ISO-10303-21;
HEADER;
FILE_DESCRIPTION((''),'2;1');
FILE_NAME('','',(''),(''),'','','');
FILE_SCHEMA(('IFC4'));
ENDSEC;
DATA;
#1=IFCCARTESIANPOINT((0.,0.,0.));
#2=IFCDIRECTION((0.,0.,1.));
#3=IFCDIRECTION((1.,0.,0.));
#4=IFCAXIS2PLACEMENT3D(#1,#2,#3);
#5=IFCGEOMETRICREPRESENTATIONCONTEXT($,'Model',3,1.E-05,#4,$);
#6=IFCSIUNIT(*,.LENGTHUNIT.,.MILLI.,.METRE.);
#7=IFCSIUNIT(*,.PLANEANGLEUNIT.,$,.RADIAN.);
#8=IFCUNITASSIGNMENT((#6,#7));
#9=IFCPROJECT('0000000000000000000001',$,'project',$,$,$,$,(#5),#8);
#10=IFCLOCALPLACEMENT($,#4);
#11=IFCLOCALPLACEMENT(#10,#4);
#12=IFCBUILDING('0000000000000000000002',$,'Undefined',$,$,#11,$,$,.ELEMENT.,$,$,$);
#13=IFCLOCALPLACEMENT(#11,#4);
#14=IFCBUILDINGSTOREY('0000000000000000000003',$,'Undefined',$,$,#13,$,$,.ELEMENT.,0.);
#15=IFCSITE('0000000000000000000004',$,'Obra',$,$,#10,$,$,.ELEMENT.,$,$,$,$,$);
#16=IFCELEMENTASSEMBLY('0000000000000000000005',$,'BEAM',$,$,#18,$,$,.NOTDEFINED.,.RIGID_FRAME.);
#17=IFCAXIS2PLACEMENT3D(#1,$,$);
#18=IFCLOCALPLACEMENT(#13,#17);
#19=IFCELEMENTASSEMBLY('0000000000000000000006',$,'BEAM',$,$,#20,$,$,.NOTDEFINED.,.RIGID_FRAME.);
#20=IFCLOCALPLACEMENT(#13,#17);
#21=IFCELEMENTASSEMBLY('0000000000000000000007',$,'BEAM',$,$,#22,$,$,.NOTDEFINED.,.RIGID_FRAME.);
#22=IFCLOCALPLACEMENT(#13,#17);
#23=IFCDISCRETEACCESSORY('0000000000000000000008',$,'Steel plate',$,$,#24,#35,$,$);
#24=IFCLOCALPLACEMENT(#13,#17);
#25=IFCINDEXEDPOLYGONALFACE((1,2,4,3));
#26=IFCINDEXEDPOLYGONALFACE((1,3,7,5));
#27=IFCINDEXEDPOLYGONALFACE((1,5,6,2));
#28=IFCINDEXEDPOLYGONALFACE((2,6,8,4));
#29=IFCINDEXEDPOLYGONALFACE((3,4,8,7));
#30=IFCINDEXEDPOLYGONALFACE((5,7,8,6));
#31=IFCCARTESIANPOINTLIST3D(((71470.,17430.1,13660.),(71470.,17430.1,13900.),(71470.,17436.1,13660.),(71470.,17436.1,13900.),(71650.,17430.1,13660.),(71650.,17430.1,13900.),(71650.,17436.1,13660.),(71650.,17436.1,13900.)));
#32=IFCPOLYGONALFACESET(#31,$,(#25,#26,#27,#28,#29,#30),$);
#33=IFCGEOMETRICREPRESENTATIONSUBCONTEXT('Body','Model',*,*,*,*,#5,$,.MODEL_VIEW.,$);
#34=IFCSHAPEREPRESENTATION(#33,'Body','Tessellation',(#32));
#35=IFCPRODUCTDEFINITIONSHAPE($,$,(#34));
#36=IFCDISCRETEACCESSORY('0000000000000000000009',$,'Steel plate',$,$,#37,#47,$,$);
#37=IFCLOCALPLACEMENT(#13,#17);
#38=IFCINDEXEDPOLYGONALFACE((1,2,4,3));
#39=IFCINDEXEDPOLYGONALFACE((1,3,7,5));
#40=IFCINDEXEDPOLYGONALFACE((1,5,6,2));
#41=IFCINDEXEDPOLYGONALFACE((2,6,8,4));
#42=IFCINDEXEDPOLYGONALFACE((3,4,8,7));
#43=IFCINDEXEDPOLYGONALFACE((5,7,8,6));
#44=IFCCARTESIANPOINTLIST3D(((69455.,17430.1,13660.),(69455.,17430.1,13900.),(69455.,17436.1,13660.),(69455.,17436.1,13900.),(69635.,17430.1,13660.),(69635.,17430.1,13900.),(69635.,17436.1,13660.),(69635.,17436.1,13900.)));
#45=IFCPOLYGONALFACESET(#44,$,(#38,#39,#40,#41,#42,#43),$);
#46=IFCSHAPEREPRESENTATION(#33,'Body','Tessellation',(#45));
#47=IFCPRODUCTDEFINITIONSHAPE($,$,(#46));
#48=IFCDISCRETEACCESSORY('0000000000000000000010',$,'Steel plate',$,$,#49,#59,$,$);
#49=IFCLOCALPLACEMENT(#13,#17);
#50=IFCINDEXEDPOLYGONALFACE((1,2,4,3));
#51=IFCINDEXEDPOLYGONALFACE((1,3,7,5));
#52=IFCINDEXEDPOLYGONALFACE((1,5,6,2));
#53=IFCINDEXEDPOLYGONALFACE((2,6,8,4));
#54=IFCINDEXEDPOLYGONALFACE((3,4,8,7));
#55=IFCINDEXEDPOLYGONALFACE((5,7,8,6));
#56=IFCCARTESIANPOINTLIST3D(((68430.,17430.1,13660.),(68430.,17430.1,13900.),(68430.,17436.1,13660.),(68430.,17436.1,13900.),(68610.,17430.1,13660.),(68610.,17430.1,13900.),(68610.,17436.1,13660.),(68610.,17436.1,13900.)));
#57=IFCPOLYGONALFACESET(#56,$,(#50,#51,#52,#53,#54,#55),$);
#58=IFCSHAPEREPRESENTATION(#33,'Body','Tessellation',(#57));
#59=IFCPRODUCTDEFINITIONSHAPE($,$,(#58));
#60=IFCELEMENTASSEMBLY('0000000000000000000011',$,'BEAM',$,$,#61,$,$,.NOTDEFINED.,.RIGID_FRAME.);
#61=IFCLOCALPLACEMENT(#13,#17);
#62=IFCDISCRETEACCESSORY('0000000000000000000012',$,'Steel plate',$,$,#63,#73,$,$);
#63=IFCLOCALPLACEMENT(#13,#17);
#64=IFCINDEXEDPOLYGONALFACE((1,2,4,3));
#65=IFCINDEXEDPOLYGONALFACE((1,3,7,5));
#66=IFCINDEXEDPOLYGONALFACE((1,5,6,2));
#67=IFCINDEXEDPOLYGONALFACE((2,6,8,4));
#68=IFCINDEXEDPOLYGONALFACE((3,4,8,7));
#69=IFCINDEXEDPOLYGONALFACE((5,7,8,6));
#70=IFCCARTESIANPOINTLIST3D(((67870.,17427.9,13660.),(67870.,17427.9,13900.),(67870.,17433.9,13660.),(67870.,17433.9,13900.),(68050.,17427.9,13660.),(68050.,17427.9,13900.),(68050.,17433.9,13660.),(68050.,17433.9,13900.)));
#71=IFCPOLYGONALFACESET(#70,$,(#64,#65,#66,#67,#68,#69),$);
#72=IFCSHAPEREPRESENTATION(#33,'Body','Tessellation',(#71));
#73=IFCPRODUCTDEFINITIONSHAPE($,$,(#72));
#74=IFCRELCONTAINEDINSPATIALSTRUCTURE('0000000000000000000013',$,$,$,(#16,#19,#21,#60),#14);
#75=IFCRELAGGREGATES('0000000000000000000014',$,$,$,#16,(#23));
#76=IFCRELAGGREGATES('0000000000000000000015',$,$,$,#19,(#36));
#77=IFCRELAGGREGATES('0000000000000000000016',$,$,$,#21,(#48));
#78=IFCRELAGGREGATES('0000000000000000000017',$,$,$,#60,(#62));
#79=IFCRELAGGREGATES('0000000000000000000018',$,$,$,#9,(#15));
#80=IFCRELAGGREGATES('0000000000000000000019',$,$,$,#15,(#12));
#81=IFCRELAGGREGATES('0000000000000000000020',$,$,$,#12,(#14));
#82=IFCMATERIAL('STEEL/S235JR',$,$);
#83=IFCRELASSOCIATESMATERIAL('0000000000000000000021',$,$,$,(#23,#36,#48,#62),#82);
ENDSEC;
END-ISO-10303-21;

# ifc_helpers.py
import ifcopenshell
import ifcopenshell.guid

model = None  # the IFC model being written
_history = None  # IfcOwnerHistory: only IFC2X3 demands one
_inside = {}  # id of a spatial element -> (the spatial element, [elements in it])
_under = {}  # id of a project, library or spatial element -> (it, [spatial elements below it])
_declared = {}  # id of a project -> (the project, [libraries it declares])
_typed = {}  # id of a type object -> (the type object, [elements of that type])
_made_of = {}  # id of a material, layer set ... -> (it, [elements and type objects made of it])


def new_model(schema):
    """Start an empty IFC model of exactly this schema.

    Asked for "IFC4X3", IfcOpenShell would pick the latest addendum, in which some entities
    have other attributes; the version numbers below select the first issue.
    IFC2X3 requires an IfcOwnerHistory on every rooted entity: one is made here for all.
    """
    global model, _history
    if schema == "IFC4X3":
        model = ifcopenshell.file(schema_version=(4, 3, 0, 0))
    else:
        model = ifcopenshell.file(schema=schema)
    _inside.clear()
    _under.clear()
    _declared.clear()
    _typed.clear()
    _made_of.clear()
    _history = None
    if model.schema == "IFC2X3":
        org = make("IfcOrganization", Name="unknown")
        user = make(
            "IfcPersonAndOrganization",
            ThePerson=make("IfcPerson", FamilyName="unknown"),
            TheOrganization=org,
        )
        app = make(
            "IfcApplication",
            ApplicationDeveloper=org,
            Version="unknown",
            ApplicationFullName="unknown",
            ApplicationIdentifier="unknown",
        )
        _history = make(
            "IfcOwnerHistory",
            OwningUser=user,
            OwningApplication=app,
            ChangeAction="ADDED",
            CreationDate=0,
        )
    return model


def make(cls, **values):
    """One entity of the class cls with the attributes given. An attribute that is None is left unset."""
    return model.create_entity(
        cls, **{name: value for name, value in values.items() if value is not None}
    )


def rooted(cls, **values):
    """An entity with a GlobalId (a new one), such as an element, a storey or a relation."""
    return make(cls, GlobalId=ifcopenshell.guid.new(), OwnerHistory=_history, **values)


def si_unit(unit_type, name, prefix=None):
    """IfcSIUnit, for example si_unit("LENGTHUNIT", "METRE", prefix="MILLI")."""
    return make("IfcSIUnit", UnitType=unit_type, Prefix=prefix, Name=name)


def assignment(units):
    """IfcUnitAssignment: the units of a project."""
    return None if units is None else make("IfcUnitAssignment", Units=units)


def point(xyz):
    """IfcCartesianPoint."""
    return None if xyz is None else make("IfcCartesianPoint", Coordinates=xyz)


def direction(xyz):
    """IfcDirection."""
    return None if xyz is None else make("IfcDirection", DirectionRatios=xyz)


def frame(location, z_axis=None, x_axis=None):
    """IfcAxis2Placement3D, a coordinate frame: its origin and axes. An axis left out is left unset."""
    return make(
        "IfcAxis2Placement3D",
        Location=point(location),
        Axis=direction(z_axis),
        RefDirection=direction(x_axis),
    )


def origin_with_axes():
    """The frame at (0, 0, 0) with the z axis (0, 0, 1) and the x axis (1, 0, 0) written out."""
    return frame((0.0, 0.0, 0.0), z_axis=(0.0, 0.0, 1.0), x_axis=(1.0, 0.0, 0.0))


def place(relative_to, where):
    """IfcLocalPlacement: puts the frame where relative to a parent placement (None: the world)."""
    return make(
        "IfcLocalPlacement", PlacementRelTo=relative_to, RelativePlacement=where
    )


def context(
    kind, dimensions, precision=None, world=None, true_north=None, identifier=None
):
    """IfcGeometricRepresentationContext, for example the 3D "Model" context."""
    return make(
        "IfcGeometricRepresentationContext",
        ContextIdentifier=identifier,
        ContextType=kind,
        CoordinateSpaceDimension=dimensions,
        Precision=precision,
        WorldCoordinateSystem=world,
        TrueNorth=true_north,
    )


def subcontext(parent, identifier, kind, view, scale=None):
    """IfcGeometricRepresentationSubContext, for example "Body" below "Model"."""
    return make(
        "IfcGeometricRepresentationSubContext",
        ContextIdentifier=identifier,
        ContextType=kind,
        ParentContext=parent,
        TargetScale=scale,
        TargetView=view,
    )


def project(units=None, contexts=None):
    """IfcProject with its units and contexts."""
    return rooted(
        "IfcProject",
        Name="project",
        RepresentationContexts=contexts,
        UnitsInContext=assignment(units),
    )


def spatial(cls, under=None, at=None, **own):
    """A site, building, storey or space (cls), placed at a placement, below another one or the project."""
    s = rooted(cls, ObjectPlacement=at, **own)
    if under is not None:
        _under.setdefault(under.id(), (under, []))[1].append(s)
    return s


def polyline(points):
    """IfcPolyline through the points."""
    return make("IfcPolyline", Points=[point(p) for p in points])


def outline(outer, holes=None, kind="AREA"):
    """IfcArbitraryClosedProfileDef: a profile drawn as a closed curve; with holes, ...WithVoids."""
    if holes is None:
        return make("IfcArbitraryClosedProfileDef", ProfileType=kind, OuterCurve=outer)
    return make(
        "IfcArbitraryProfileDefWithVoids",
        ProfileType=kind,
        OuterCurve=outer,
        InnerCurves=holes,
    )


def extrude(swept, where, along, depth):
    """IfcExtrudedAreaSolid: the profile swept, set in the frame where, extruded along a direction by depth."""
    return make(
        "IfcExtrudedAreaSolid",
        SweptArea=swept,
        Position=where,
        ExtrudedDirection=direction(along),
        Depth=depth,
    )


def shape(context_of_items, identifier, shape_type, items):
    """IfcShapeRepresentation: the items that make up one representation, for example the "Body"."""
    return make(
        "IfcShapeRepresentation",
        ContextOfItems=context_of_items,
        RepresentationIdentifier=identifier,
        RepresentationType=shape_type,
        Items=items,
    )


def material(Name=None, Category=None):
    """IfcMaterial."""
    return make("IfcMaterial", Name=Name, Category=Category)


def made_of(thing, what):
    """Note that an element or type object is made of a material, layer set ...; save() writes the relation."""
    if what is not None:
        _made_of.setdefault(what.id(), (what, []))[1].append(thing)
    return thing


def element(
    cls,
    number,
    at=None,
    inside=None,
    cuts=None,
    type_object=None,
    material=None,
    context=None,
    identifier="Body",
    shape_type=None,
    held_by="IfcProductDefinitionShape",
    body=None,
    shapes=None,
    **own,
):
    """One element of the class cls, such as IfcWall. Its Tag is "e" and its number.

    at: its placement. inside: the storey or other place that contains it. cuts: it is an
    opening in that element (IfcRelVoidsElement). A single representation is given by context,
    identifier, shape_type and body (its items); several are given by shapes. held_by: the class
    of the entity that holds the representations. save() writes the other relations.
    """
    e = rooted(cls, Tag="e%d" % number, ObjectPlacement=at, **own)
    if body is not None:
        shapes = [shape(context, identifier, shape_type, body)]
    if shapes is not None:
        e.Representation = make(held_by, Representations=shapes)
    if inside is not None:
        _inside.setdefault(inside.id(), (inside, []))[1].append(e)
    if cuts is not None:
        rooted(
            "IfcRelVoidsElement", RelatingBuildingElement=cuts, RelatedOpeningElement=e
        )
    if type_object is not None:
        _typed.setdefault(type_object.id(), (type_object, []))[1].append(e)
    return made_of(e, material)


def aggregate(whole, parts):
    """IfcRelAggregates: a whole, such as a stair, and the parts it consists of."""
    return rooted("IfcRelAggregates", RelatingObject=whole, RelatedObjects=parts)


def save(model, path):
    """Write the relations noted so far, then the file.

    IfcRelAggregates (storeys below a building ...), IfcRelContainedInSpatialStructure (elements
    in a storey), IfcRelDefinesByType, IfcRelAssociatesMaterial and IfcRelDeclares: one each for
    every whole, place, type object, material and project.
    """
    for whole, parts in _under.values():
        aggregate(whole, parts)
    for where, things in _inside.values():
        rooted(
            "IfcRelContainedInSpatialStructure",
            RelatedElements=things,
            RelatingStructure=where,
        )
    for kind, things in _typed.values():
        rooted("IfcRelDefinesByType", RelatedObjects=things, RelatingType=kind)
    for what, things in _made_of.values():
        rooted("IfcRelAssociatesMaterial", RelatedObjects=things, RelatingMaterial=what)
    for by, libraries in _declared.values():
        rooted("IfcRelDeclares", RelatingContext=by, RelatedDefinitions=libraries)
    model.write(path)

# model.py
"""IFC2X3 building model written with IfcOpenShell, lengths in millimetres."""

from ifc_helpers import new_model, si_unit, frame, origin_with_axes, place, context, subcontext, project, spatial, polyline, outline, extrude, material, element, aggregate, save


model = new_model("IFC2X3")

# Units and contexts
model_context = context("Model", 3, precision=1e-05, world=origin_with_axes())
body_context = subcontext(model_context, "Body", "Model", "MODEL_VIEW")
ifc_project = project(units=[si_unit("LENGTHUNIT", "METRE", prefix="MILLI"), si_unit("PLANEANGLEUNIT", "RADIAN")], contexts=[model_context])

# Site, building, storey
site_placement = place(None, origin_with_axes())
site = spatial("IfcSite", under=ifc_project, at=site_placement, Name="Obra", CompositionType="ELEMENT")
building_placement = place(site_placement, origin_with_axes())
building = spatial("IfcBuilding", under=site, at=building_placement, Name="Undefined", CompositionType="ELEMENT")
storey_placement = place(building_placement, origin_with_axes())
storey = spatial("IfcBuildingStorey", under=building, at=storey_placement, Name="Undefined", CompositionType="ELEMENT", Elevation=0.0)

# Element assemblies
assembly_1_placement = place(storey_placement, origin_with_axes())
assembly_1 = element("IfcElementAssembly", 1, at=assembly_1_placement, inside=storey, Name="BEAM", AssemblyPlace="NOTDEFINED", PredefinedType="RIGID_FRAME")
ifc_material_1 = material(Name="STEEL/S235JR")
assembly_2_placement = place(storey_placement, origin_with_axes())
assembly_2 = element("IfcElementAssembly", 2, at=assembly_2_placement, inside=storey, Name="BEAM", AssemblyPlace="NOTDEFINED", PredefinedType="RIGID_FRAME")
assembly_3_placement = place(storey_placement, origin_with_axes())
assembly_3 = element("IfcElementAssembly", 3, at=assembly_3_placement, inside=storey, Name="BEAM", AssemblyPlace="NOTDEFINED", PredefinedType="RIGID_FRAME")

# Discrete accessories
discrete_accessory_1_placement = place(assembly_1_placement, frame((71470.0, 17433.1, 13900.0), z_axis=(0.0, 1.0, 0.0), x_axis=(1.0, 0.0, 0.0)))
discrete_accessory_1 = element("IfcDiscreteAccessory", 4, at=discrete_accessory_1_placement, material=ifc_material_1, Name="Steel plate", context=body_context, shape_type="SweptSolid", body=[
    extrude(outline(polyline([(0.0, 0.0), (180.0, 0.0), (180.0, 240.0), (0.0, 240.0), (0.0, 0.0)])), frame((0.0, 0.0, -3.0), z_axis=(0.0, 0.0, 1.0), x_axis=(1.0, 0.0, 0.0)), (0.0, 0.0, 1.0), 6.0),
])
aggregate(assembly_1, [discrete_accessory_1])
discrete_accessory_2_placement = place(assembly_2_placement, frame((69455.0, 17433.1, 13900.0), z_axis=(0.0, 1.0, 0.0), x_axis=(1.0, 0.0, 0.0)))
discrete_accessory_2 = element("IfcDiscreteAccessory", 5, at=discrete_accessory_2_placement, material=ifc_material_1, Name="Steel plate", context=body_context, shape_type="SweptSolid", body=[
    extrude(outline(polyline([(0.0, 0.0), (180.0, 0.0), (180.0, 240.0), (0.0, 240.0), (0.0, 0.0)])), frame((0.0, 0.0, -3.0), z_axis=(0.0, 0.0, 1.0), x_axis=(1.0, 0.0, 0.0)), (0.0, 0.0, 1.0), 6.0),
])
aggregate(assembly_2, [discrete_accessory_2])
discrete_accessory_3_placement = place(assembly_3_placement, frame((68430.0, 17433.1, 13900.0), z_axis=(0.0, 1.0, 0.0), x_axis=(1.0, 0.0, 0.0)))
discrete_accessory_3 = element("IfcDiscreteAccessory", 6, at=discrete_accessory_3_placement, material=ifc_material_1, Name="Steel plate", context=body_context, shape_type="SweptSolid", body=[
    extrude(outline(polyline([(0.0, 0.0), (180.0, 0.0), (180.0, 240.0), (0.0, 240.0), (0.0, 0.0)])), frame((0.0, 0.0, -3.0), z_axis=(0.0, 0.0, 1.0), x_axis=(1.0, 0.0, 0.0)), (0.0, 0.0, 1.0), 6.0),
])
aggregate(assembly_3, [discrete_accessory_3])

# Element assembly, discrete accessory
assembly_4_placement = place(storey_placement, origin_with_axes())
assembly_4 = element("IfcElementAssembly", 7, at=assembly_4_placement, inside=storey, Name="BEAM", AssemblyPlace="NOTDEFINED", PredefinedType="RIGID_FRAME")
discrete_accessory_4_placement = place(assembly_4_placement, frame((67870.0, 17430.9, 13900.0), z_axis=(0.0, 1.0, 0.0), x_axis=(1.0, 0.0, 0.0)))
discrete_accessory_4 = element("IfcDiscreteAccessory", 8, at=discrete_accessory_4_placement, material=ifc_material_1, Name="Steel plate", context=body_context, shape_type="SweptSolid", body=[
    extrude(outline(polyline([(0.0, 0.0), (180.0, 0.0), (180.0, 240.0), (0.0, 240.0), (0.0, 0.0)])), frame((0.0, 0.0, -3.0), z_axis=(0.0, 0.0, 1.0), x_axis=(1.0, 0.0, 0.0)), (0.0, 0.0, 1.0), 6.0),
])
aggregate(assembly_4, [discrete_accessory_4])

save(model, "model.ifc")
